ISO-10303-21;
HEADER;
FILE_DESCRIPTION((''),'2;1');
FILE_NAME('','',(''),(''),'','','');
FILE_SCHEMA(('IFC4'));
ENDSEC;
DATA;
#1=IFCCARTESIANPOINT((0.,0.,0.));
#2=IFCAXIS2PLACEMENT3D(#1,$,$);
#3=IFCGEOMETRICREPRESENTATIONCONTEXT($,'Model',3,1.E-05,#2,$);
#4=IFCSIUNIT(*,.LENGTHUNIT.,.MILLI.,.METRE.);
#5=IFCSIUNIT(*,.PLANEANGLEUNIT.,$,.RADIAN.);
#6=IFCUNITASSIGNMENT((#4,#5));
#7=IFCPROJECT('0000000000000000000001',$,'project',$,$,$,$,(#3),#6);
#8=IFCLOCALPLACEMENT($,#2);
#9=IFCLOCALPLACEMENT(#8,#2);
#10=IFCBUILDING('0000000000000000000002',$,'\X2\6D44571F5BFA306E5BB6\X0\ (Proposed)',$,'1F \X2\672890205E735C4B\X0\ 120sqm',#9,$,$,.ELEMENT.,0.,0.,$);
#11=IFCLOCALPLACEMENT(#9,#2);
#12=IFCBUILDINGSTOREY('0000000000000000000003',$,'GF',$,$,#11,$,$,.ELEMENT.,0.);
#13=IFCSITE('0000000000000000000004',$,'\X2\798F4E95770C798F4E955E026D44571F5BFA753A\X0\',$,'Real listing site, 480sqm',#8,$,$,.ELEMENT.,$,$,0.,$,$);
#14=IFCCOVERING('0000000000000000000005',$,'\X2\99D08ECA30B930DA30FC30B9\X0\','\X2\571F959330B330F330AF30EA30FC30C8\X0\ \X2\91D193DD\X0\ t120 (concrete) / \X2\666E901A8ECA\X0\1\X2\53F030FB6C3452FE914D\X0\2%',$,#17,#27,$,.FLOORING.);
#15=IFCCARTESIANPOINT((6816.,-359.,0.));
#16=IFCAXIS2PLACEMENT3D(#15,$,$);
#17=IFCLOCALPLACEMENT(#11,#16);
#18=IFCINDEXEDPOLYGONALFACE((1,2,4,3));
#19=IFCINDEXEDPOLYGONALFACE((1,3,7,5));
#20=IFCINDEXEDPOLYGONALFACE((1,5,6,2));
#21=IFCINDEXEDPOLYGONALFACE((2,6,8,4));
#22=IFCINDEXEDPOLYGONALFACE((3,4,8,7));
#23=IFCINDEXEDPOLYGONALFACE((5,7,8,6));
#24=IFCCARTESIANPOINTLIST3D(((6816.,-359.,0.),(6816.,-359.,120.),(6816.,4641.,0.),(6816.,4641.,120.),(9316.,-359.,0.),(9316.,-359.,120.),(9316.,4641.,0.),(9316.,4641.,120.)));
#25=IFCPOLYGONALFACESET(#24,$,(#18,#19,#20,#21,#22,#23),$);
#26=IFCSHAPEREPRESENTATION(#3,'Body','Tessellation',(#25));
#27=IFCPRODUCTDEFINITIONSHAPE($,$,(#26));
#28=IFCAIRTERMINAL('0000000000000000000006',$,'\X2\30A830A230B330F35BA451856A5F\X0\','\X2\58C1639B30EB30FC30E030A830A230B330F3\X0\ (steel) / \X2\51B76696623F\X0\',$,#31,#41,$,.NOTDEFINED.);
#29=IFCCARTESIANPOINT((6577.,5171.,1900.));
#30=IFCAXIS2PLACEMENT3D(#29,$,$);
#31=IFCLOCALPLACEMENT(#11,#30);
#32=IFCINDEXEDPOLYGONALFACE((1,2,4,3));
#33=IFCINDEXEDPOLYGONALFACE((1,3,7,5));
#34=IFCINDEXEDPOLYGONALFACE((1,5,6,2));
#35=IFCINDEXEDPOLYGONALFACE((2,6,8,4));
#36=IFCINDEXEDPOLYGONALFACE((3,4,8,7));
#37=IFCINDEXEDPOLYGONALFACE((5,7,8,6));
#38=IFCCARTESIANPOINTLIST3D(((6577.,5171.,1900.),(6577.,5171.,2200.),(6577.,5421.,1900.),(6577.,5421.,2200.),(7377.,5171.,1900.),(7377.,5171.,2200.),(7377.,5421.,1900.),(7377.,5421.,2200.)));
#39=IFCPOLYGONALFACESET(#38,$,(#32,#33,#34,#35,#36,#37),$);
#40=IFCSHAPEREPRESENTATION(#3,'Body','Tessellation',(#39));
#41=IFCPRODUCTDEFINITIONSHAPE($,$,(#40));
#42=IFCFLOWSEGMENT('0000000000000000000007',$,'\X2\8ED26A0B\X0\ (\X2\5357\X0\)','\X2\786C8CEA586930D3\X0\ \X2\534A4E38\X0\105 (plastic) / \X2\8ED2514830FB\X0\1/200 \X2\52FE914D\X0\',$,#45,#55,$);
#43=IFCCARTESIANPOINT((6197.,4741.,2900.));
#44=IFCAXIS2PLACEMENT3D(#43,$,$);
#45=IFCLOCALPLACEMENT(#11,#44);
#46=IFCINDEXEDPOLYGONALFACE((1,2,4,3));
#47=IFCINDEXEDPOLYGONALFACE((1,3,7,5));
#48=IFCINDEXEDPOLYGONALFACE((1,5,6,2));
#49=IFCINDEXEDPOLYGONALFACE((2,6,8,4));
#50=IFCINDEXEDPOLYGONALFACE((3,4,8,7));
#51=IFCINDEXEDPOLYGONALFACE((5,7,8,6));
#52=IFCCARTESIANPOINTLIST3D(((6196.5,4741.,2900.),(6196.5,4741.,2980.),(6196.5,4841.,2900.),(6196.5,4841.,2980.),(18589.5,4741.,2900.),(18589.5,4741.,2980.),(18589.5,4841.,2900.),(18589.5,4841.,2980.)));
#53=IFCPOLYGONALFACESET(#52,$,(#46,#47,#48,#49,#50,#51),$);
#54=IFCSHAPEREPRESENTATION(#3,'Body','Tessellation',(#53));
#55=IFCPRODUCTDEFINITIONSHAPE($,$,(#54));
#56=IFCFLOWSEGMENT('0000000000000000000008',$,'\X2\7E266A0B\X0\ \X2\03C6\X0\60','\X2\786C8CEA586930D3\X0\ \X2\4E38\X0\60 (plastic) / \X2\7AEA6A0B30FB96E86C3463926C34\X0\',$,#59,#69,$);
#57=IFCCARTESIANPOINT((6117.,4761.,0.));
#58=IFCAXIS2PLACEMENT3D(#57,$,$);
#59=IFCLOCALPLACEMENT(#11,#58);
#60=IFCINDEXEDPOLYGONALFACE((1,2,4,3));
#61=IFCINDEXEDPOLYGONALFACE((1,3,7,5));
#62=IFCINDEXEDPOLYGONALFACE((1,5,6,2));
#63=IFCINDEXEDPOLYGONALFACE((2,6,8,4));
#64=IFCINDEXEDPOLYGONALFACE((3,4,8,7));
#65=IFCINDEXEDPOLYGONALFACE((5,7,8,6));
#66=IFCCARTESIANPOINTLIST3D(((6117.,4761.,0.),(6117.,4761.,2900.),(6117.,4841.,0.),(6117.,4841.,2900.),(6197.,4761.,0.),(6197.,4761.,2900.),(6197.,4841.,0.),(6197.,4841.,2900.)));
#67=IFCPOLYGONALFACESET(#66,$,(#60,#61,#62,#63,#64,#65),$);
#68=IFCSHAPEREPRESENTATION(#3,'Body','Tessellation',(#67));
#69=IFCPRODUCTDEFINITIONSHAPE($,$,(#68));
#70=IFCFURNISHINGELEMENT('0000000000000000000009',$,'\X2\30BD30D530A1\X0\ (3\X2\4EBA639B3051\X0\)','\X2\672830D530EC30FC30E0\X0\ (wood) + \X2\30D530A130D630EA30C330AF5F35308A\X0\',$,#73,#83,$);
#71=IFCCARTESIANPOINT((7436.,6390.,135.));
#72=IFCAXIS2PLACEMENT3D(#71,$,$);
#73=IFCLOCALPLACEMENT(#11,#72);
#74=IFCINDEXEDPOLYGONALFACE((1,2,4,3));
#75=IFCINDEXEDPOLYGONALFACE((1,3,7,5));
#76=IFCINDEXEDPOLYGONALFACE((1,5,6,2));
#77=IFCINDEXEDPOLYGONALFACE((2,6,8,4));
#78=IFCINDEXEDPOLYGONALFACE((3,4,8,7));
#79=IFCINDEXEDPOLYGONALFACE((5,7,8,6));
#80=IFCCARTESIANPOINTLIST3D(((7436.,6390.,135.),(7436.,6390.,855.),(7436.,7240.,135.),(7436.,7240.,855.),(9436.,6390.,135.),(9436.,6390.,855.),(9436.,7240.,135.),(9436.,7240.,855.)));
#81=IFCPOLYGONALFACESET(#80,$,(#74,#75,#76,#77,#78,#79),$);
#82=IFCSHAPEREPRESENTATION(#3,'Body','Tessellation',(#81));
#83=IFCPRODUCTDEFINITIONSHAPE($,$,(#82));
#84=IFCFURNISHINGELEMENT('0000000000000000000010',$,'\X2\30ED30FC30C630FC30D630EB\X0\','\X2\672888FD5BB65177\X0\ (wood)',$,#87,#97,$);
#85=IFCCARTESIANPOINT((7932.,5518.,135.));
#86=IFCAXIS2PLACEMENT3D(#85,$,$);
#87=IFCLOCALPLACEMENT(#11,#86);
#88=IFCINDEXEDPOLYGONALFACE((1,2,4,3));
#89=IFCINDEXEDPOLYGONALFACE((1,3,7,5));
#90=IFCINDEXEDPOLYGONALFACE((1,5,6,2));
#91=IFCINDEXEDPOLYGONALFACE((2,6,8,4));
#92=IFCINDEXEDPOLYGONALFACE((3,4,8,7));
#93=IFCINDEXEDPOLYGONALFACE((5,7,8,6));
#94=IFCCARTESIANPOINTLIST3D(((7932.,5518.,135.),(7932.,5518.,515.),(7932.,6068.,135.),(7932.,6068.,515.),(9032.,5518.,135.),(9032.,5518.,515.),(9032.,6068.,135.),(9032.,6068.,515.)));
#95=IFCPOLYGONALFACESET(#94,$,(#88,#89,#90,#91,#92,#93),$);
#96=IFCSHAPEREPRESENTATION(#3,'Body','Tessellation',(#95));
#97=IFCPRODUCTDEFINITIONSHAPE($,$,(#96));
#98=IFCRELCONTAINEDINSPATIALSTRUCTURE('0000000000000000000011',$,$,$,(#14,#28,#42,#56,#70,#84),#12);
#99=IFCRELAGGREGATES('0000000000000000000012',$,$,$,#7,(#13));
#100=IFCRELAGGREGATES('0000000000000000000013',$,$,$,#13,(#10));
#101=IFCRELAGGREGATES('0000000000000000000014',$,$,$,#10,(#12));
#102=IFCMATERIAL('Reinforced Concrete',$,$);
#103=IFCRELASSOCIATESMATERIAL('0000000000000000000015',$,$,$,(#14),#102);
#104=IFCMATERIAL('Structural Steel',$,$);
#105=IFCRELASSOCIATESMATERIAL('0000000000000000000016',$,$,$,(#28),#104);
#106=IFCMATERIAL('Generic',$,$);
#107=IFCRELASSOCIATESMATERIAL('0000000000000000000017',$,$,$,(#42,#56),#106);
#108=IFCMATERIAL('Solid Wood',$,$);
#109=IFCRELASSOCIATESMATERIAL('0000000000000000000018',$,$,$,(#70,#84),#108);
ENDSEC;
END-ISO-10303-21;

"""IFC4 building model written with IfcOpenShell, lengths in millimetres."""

from ifc_helpers import new_model, si_unit, frame, frame_2d, origin, place, context, project, spatial, rectangle, extrude, material, element, save


model = new_model("IFC4")

# Units and contexts
model_context = context("Model", 3, precision=1e-05, world=origin())
ifc_project = project(units=[si_unit("LENGTHUNIT", "METRE", prefix="MILLI"), si_unit("PLANEANGLEUNIT", "RADIAN")], contexts=[model_context])

# Site, building, storey
site_placement = place(None, origin())
site = spatial("IfcSite", under=ifc_project, at=site_placement, Name="福井県福井市浄土寺町", ObjectType="Real listing site, 480sqm", CompositionType="ELEMENT", RefElevation=0.0)
building_placement = place(site_placement, origin())
building = spatial("IfcBuilding", under=site, at=building_placement, Name="浄土寺の家 (Proposed)", ObjectType="1F 木造平屋 120sqm", CompositionType="ELEMENT", ElevationOfRefHeight=0.0, ElevationOfTerrain=0.0)
storey_placement = place(building_placement, origin())
storey = spatial("IfcBuildingStorey", under=building, at=storey_placement, Name="GF", CompositionType="ELEMENT", Elevation=0.0)

# Shared definitions
ifc_material_1 = material(Name="Solid Wood")

# Shared definitions
ifc_material_2 = material(Name="Reinforced Concrete")

# Shared definitions
ifc_material_3 = material(Name="Structural Steel")

# Covering
ifc_material_4 = material(Name="Generic")
covering_1_placement = place(storey_placement, frame((6816.0, -359.0, 0.0)))
element("IfcCovering", 1, at=covering_1_placement, inside=storey, material=ifc_material_2, Name="駐車スペース", Description="土間コンクリート 金鏝 t120 (concrete) / 普通車1台・水勾配2%", PredefinedType="FLOORING", context=model_context, shape_type="SweptSolid", body=[
    extrude(rectangle(XDim=2500.0, YDim=5000.0, at=frame_2d((1250.0, 2500.0))), frame((6816.0, -359.0, 0.0)), (0.0, 0.0, 1.0), 120.0),
])

# Air terminal
air_terminal_placement = place(storey_placement, frame((6577.0, 5171.0, 1900.0)))
element("IfcAirTerminal", 2, at=air_terminal_placement, inside=storey, material=ifc_material_3, Name="エアコン室内機", Description="壁掛ルームエアコン (steel) / 冷暖房", PredefinedType="NOTDEFINED", context=model_context, shape_type="SweptSolid", body=[
    extrude(rectangle(XDim=800.0, YDim=250.0, at=frame_2d((400.0, 125.0))), frame((6577.0, 5171.0, 1900.0)), (0.0, 0.0, 1.0), 300.0),
])

# Flow segments
flow_segment_1_placement = place(storey_placement, frame((6197.0, 4741.0, 2900.0)))
element("IfcFlowSegment", 3, at=flow_segment_1_placement, inside=storey, material=ifc_material_4, Name="軒樋 (南)", Description="硬質塩ビ 半丸105 (plastic) / 軒先・1/200 勾配", context=model_context, shape_type="SweptSolid", body=[
    extrude(rectangle(XDim=12393.0, YDim=100.0, at=frame_2d((6196.0, 50.0))), frame((6197.0, 4741.0, 2900.0)), (0.0, 0.0, 1.0), 80.0),
])
flow_segment_2_placement = place(storey_placement, frame((6117.0, 4761.0, 0.0)))
element("IfcFlowSegment", 4, at=flow_segment_2_placement, inside=storey, material=ifc_material_4, Name="縦樋 φ60", Description="硬質塩ビ 丸60 (plastic) / 竪樋・雨水排水", context=model_context, shape_type="SweptSolid", body=[
    extrude(rectangle(XDim=80.0, YDim=80.0, at=frame_2d((40.0, 40.0))), frame((6117.0, 4761.0, 0.0)), (0.0, 0.0, 1.0), 2900.0),
])

# Furnishing elements
furnishing_1_placement = place(storey_placement, frame((7436.0, 6390.0, 135.0)))
element("IfcFurnishingElement", 5, at=furnishing_1_placement, inside=storey, material=ifc_material_1, Name="ソファ (3人掛け)", Description="木フレーム (wood) + ファブリック張り", context=model_context, shape_type="SweptSolid", body=[
    extrude(rectangle(XDim=2000.0, YDim=850.0, at=frame_2d((1000.0, 425.0))), frame((7436.0, 6390.0, 135.0)), (0.0, 0.0, 1.0), 720.0),
])
furnishing_2_placement = place(storey_placement, frame((7932.0, 5518.0, 135.0)))
element("IfcFurnishingElement", 6, at=furnishing_2_placement, inside=storey, material=ifc_material_1, Name="ローテーブル", Description="木製家具 (wood)", context=model_context, shape_type="SweptSolid", body=[
    extrude(rectangle(XDim=1100.0, YDim=550.0, at=frame_2d((550.0, 275.0))), frame((7932.0, 5518.0, 135.0)), (0.0, 0.0, 1.0), 380.0),
])

save(model, "model.ifc")
